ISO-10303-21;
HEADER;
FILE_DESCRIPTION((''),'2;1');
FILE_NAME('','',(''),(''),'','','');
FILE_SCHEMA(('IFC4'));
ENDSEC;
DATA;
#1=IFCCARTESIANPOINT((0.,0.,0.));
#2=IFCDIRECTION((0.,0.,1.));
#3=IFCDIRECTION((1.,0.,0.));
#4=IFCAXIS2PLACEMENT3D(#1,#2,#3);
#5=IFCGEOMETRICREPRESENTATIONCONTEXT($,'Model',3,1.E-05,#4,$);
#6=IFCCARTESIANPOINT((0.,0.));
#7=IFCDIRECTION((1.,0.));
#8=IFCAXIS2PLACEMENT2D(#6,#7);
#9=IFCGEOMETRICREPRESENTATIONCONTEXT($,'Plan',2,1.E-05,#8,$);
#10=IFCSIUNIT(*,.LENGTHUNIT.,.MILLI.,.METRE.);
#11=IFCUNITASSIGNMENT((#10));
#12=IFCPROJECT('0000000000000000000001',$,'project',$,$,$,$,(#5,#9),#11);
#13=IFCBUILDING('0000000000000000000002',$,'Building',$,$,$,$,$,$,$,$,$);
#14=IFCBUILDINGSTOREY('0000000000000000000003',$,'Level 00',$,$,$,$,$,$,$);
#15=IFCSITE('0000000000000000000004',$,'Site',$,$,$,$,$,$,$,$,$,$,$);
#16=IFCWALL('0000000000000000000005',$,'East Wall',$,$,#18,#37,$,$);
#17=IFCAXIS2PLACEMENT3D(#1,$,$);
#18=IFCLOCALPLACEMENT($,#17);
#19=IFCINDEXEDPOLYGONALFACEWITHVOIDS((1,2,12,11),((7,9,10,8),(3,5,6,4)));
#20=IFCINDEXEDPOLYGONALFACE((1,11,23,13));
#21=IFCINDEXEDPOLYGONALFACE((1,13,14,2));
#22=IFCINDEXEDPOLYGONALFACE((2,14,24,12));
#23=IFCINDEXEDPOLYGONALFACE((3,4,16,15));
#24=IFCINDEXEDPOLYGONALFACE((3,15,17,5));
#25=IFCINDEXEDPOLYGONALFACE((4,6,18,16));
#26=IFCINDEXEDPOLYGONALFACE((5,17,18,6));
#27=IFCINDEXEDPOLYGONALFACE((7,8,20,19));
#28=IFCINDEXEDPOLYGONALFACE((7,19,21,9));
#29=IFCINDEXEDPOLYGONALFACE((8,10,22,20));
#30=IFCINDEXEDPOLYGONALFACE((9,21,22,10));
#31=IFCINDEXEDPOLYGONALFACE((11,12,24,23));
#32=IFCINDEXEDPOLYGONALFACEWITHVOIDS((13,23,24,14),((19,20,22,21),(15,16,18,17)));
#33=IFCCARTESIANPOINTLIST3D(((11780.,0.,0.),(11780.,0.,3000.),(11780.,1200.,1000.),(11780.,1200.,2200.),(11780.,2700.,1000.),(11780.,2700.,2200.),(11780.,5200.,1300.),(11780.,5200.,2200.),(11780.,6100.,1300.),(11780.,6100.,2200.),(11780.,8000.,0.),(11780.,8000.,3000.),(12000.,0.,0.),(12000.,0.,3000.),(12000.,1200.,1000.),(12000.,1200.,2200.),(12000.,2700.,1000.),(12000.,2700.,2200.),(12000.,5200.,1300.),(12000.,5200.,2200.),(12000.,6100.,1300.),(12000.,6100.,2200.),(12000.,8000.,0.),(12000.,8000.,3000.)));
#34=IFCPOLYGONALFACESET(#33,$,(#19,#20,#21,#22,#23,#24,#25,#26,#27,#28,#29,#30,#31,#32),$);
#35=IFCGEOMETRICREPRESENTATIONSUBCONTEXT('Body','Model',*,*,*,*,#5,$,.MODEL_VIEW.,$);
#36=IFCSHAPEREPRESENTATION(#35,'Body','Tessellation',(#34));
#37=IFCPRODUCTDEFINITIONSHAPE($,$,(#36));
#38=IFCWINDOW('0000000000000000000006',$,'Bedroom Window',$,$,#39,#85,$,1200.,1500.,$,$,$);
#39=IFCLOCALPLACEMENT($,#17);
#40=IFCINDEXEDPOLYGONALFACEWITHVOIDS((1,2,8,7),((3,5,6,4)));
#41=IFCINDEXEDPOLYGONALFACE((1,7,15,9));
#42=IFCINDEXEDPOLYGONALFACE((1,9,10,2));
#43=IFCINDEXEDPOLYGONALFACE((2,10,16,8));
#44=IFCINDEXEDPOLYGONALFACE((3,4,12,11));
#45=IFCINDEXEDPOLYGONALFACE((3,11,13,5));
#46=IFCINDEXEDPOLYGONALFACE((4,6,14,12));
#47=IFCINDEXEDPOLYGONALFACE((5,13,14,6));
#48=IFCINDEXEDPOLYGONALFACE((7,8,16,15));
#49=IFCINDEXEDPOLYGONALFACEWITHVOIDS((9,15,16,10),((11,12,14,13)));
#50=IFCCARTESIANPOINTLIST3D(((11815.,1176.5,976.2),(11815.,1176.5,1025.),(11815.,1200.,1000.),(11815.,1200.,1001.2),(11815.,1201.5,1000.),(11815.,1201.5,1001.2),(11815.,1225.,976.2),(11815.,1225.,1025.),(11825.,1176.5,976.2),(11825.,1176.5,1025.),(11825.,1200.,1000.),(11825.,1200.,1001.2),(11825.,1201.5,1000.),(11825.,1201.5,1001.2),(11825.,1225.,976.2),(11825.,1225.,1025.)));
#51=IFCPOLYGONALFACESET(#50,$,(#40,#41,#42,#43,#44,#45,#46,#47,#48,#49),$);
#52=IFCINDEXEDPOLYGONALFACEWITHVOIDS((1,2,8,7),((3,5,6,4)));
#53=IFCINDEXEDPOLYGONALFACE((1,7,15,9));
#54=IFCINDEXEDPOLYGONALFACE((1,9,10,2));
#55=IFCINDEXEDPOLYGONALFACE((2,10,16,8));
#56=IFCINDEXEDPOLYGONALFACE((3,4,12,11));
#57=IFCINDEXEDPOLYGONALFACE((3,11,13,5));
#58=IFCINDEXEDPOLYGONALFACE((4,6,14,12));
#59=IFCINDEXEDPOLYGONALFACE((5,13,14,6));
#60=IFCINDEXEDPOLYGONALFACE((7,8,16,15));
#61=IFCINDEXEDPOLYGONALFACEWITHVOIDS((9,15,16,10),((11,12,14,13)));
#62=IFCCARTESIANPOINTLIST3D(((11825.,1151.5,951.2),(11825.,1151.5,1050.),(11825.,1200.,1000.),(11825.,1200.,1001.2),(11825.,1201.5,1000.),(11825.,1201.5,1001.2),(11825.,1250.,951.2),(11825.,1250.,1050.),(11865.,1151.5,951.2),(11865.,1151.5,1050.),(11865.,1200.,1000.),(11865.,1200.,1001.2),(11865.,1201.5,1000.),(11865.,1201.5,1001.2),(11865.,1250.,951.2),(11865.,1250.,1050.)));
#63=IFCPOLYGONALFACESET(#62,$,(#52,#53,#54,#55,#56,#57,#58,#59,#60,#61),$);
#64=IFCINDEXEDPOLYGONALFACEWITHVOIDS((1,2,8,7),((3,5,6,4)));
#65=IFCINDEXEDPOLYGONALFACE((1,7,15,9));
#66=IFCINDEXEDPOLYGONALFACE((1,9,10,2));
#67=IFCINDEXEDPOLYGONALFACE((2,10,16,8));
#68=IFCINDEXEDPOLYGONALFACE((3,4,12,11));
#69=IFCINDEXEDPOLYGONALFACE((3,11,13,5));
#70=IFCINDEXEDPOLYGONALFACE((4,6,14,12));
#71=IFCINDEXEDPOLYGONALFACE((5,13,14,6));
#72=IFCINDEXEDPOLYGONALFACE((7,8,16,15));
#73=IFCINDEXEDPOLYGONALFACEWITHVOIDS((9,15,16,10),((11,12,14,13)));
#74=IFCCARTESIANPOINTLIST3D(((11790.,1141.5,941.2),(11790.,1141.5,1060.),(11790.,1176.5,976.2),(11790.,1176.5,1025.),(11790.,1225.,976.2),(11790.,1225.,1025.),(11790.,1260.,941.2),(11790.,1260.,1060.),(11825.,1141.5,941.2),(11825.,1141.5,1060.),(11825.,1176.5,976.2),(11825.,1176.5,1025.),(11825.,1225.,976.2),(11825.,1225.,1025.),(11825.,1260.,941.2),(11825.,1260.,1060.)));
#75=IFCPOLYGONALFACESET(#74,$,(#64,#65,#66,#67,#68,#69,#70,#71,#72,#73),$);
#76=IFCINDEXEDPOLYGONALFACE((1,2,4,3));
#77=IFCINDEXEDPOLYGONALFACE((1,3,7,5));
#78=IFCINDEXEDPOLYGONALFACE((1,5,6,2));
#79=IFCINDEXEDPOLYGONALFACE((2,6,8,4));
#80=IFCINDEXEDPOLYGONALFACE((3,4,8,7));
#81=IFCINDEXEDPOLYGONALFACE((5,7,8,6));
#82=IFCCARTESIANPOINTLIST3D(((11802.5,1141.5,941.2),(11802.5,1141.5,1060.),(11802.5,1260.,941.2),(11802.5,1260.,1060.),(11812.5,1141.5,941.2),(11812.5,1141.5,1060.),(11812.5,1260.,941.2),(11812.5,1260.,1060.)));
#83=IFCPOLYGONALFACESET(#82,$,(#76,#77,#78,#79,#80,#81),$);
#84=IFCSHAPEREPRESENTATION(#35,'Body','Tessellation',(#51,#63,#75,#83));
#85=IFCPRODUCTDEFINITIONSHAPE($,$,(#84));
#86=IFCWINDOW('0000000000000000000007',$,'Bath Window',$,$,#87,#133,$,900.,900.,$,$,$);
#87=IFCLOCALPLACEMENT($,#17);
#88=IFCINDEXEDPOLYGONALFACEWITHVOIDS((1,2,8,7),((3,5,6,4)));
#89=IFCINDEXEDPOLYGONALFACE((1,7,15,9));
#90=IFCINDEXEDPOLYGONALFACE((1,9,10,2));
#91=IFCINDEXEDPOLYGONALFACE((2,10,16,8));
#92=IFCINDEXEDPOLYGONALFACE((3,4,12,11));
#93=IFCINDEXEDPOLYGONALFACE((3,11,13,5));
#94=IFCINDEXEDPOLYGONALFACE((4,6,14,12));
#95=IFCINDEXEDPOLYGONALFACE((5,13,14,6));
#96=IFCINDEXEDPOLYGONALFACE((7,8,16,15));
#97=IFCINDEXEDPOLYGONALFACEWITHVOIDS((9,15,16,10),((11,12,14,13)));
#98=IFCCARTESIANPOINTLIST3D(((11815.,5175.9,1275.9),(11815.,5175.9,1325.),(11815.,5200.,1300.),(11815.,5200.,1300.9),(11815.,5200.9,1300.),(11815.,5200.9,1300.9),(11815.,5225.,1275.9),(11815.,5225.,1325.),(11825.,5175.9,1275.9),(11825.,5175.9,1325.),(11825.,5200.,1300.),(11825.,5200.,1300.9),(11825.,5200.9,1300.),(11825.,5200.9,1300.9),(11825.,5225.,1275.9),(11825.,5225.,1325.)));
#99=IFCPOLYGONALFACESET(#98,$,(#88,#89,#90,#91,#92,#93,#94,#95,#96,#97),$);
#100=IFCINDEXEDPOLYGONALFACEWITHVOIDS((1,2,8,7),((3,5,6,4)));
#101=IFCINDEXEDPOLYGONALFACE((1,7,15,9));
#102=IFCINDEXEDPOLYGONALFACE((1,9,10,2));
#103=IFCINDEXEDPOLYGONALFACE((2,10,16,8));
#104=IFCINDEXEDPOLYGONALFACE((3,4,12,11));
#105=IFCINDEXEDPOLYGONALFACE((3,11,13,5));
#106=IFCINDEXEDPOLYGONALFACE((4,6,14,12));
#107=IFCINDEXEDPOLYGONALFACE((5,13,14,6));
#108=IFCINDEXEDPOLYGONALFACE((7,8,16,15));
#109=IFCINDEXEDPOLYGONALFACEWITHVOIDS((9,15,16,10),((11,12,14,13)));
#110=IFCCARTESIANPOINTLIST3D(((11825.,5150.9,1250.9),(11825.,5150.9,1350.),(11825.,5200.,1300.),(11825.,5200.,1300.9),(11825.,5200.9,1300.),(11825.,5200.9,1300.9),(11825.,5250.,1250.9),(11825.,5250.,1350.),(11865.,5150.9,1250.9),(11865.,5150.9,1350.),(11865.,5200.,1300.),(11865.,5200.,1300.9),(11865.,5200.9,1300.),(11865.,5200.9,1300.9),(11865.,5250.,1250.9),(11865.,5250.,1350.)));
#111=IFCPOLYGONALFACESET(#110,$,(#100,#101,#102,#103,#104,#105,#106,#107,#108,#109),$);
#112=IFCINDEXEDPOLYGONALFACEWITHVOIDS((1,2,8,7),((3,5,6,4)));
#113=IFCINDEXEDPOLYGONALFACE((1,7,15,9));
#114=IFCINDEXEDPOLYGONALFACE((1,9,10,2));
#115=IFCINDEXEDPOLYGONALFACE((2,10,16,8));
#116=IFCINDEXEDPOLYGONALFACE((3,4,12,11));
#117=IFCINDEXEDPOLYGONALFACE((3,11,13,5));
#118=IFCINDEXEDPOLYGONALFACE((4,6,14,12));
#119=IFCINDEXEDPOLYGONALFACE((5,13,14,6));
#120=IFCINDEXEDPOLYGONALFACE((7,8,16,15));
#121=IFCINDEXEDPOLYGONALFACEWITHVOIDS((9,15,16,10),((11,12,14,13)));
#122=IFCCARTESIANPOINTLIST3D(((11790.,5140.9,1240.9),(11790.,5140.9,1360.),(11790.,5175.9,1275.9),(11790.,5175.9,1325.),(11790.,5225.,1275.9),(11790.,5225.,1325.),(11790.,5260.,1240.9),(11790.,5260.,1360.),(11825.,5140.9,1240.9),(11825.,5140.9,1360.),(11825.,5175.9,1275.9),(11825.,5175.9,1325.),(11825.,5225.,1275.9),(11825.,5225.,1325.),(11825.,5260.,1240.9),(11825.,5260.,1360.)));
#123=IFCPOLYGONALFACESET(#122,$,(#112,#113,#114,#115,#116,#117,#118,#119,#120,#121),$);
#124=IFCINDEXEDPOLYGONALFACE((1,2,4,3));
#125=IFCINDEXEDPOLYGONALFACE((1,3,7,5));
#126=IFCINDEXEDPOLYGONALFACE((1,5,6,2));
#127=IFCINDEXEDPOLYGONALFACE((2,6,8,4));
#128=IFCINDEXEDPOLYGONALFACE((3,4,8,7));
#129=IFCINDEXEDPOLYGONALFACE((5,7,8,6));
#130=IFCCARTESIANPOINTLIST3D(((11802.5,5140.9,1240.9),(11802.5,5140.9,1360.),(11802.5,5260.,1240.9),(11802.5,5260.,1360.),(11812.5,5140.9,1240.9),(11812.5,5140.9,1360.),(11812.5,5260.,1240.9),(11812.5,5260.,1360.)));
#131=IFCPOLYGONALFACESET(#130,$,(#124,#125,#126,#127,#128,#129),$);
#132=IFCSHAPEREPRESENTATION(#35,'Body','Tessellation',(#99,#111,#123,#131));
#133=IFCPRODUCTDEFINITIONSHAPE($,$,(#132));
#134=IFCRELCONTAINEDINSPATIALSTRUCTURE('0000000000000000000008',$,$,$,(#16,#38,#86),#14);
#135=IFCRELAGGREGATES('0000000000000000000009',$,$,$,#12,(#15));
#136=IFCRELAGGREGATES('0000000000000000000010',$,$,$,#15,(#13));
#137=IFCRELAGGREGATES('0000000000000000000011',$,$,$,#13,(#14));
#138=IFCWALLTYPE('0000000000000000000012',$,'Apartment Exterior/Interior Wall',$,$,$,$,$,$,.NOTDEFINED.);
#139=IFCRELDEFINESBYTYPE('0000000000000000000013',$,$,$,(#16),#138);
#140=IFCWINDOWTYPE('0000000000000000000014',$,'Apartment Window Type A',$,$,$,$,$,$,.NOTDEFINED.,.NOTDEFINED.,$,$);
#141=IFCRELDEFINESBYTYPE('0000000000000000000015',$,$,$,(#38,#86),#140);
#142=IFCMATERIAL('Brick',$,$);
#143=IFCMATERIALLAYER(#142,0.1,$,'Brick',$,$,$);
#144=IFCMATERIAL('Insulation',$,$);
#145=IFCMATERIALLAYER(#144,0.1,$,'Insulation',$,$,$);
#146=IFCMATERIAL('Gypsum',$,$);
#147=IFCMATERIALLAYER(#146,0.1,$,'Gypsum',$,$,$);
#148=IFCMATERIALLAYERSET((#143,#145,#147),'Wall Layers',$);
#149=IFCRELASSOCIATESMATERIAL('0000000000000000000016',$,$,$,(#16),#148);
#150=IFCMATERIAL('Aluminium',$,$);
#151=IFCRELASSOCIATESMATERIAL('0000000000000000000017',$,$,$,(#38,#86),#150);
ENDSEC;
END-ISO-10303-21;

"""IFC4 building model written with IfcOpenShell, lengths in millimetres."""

from ifc_helpers import new_model, si_unit, frame, origin_with_axes, origin_2d_with_axis, place, context, subcontext, project, spatial, line, indexed_curve, outline, extrude, material, layer, layer_set, layer_usage, type_object, element, fill, save


model = new_model("IFC4")

# Units and contexts
model_context = context("Model", 3, precision=1e-05, world=origin_with_axes())
plan_context = context("Plan", 2, precision=1e-05, world=origin_2d_with_axis())
body_context = subcontext(model_context, "Body", "Model", "MODEL_VIEW")
ifc_project = project(units=[si_unit("LENGTHUNIT", "METRE", prefix="MILLI")], contexts=[model_context, plan_context])

# Site, building, storey
site = spatial("IfcSite", under=ifc_project, Name="Site")
building = spatial("IfcBuilding", under=site, Name="Building")
storey = spatial("IfcBuildingStorey", under=building, Name="Level 00")

# Shared definitions
ifc_material_1 = material(Name="Brick")
ifc_layer_1 = layer(ifc_material_1, 0.1, Name="Brick")
ifc_material_2 = material(Name="Insulation")
ifc_layer_2 = layer(ifc_material_2, 0.1, Name="Insulation")
ifc_material_3 = material(Name="Gypsum")
ifc_layer_3 = layer(ifc_material_3, 0.1, Name="Gypsum")
ifc_layer_set = layer_set([ifc_layer_1, ifc_layer_2, ifc_layer_3], Name="Wall Layers")
ifc_layer_usage = layer_usage(ifc_layer_set, "AXIS2", "POSITIVE", 0.0)
wall_type = type_object("IfcWallType", Name="Apartment Exterior/Interior Wall", PredefinedType="NOTDEFINED")

# Wall, openings, windows
wall_1_placement = place(None, frame((12000.0, 0.0, 0.0), z_axis=(0.0, 0.0, 1.0), x_axis=(0.0, 1.0, 0.0)))
wall_1 = element("IfcWall", 1, at=wall_1_placement, inside=storey, type_object=wall_type, material=ifc_layer_usage, Name="East Wall", context=body_context, shape_type="SweptSolid", body=[
    extrude(outline(indexed_curve([(0.0, 0.0), (0.0, 220.0), (8000.0, 220.0), (8000.0, 0.0), (0.0, 0.0)], self_intersect=False)), origin_with_axes(), (0.0, 0.0, 1.0), 3000.0),
])
opening_1_placement = place(wall_1_placement, frame((1200.0, -22.0, 1000.0), z_axis=(0.0, 0.0, 1.0), x_axis=(1.0, 0.0, 0.0)))
opening_1 = element("IfcOpeningElement", 2, at=opening_1_placement, cuts=wall_1, context=body_context, shape_type="SweptSolid", body=[
    extrude(outline(indexed_curve([(0.0, 0.0), (0.0, 264.0), (1500.0, 264.0), (1500.0, 0.0), (0.0, 0.0)], self_intersect=False)), origin_with_axes(), (0.0, 0.0, 1.0), 1200.0),
])
opening_2_placement = place(wall_1_placement, frame((5200.0, -22.0, 1300.0), z_axis=(0.0, 0.0, 1.0), x_axis=(1.0, 0.0, 0.0)))
opening_2 = element("IfcOpeningElement", 3, at=opening_2_placement, cuts=wall_1, context=body_context, shape_type="SweptSolid", body=[
    extrude(outline(indexed_curve([(0.0, 0.0), (0.0, 264.0), (900.0, 264.0), (900.0, 0.0), (0.0, 0.0)], self_intersect=False)), origin_with_axes(), (0.0, 0.0, 1.0), 900.0),
])
ifc_material_4 = material(Name="Aluminium")
window_type = type_object("IfcWindowType", Name="Apartment Window Type A", PartitioningType="NOTDEFINED", PredefinedType="NOTDEFINED")
window_1_placement = place(opening_1_placement, frame((0.0, 107.0, 0.0), z_axis=(0.0, 0.0, 1.0), x_axis=(1.0, 0.0, 0.0)))
window_1 = element("IfcWindow", 4, at=window_1_placement, inside=storey, type_object=window_type, material=ifc_material_4, Name="Bedroom Window", OverallHeight=1200.0, OverallWidth=1500.0, context=body_context, shape_type="SweptSolid", body=[
    extrude(outline(indexed_curve([(0.0, 0.0), (1.5, 0.0), (1.5, 1.2), (0.0, 1.2)], segments=[line(1, 2, 3, 4, 1)]), holes=[indexed_curve([(25.0, 25.0), (-23.5, 25.0), (-23.5, -23.8), (25.0, -23.8)], segments=[line(1, 2, 3, 4, 1)])]), frame((0.0, 90.0, 0.0), z_axis=(0.0, -1.0, 0.0), x_axis=(1.0, 0.0, 0.0)), (0.0, 0.0, -1.0), 10.0),
    extrude(outline(indexed_curve([(0.0, 0.0), (1.5, 0.0), (1.5, 1.2), (0.0, 1.2)], segments=[line(1, 2, 3, 4, 1)]), holes=[indexed_curve([(50.0, 50.0), (-48.5, 50.0), (-48.5, -48.8), (50.0, -48.8)], segments=[line(1, 2, 3, 4, 1)])]), frame((0.0, 50.0, 0.0), z_axis=(0.0, -1.0, 0.0), x_axis=(1.0, 0.0, 0.0)), (0.0, 0.0, -1.0), 40.0),
    extrude(outline(indexed_curve([(0.0, 0.0), (-48.5, 0.0), (-48.5, -48.8), (0.0, -48.8)], segments=[line(1, 2, 3, 4, 1)]), holes=[indexed_curve([(35.0, 35.0), (-83.5, 35.0), (-83.5, -83.8), (35.0, -83.8)], segments=[line(1, 2, 3, 4, 1)])]), frame((25.0, 90.0, 25.0), z_axis=(0.0, -1.0, 0.0), x_axis=(1.0, 0.0, 0.0)), (0.0, 0.0, -1.0), 35.0),
    extrude(outline(indexed_curve([(35.0, 35.0), (-83.5, 35.0), (-83.5, -83.8), (35.0, -83.8)], segments=[line(1, 2, 3, 4, 1)])), frame((25.0, 102.5, 25.0), z_axis=(0.0, -1.0, 0.0), x_axis=(1.0, 0.0, 0.0)), (0.0, 0.0, -1.0), 10.0),
])
fill(opening_1, window_1)
window_2_placement = place(opening_2_placement, frame((0.0, 107.0, 0.0), z_axis=(0.0, 0.0, 1.0), x_axis=(1.0, 0.0, 0.0)))
window_2 = element("IfcWindow", 5, at=window_2_placement, inside=storey, type_object=window_type, material=ifc_material_4, Name="Bath Window", OverallHeight=900.0, OverallWidth=900.0, context=body_context, shape_type="SweptSolid", body=[
    extrude(outline(indexed_curve([(0.0, 0.0), (0.9, 0.0), (0.9, 0.9), (0.0, 0.9)], segments=[line(1, 2, 3, 4, 1)]), holes=[indexed_curve([(25.0, 25.0), (-24.1, 25.0), (-24.1, -24.1), (25.0, -24.1)], segments=[line(1, 2, 3, 4, 1)])]), frame((0.0, 90.0, 0.0), z_axis=(0.0, -1.0, 0.0), x_axis=(1.0, 0.0, 0.0)), (0.0, 0.0, -1.0), 10.0),
    extrude(outline(indexed_curve([(0.0, 0.0), (0.9, 0.0), (0.9, 0.9), (0.0, 0.9)], segments=[line(1, 2, 3, 4, 1)]), holes=[indexed_curve([(50.0, 50.0), (-49.1, 50.0), (-49.1, -49.1), (50.0, -49.1)], segments=[line(1, 2, 3, 4, 1)])]), frame((0.0, 50.0, 0.0), z_axis=(0.0, -1.0, 0.0), x_axis=(1.0, 0.0, 0.0)), (0.0, 0.0, -1.0), 40.0),
    extrude(outline(indexed_curve([(0.0, 0.0), (-49.1, 0.0), (-49.1, -49.1), (0.0, -49.1)], segments=[line(1, 2, 3, 4, 1)]), holes=[indexed_curve([(35.0, 35.0), (-84.1, 35.0), (-84.1, -84.1), (35.0, -84.1)], segments=[line(1, 2, 3, 4, 1)])]), frame((25.0, 90.0, 25.0), z_axis=(0.0, -1.0, 0.0), x_axis=(1.0, 0.0, 0.0)), (0.0, 0.0, -1.0), 35.0),
    extrude(outline(indexed_curve([(35.0, 35.0), (-84.1, 35.0), (-84.1, -84.1), (35.0, -84.1)], segments=[line(1, 2, 3, 4, 1)])), frame((25.0, 102.5, 25.0), z_axis=(0.0, -1.0, 0.0), x_axis=(1.0, 0.0, 0.0)), (0.0, 0.0, -1.0), 10.0),
])
fill(opening_2, window_2)

save(model, "model.ifc")
